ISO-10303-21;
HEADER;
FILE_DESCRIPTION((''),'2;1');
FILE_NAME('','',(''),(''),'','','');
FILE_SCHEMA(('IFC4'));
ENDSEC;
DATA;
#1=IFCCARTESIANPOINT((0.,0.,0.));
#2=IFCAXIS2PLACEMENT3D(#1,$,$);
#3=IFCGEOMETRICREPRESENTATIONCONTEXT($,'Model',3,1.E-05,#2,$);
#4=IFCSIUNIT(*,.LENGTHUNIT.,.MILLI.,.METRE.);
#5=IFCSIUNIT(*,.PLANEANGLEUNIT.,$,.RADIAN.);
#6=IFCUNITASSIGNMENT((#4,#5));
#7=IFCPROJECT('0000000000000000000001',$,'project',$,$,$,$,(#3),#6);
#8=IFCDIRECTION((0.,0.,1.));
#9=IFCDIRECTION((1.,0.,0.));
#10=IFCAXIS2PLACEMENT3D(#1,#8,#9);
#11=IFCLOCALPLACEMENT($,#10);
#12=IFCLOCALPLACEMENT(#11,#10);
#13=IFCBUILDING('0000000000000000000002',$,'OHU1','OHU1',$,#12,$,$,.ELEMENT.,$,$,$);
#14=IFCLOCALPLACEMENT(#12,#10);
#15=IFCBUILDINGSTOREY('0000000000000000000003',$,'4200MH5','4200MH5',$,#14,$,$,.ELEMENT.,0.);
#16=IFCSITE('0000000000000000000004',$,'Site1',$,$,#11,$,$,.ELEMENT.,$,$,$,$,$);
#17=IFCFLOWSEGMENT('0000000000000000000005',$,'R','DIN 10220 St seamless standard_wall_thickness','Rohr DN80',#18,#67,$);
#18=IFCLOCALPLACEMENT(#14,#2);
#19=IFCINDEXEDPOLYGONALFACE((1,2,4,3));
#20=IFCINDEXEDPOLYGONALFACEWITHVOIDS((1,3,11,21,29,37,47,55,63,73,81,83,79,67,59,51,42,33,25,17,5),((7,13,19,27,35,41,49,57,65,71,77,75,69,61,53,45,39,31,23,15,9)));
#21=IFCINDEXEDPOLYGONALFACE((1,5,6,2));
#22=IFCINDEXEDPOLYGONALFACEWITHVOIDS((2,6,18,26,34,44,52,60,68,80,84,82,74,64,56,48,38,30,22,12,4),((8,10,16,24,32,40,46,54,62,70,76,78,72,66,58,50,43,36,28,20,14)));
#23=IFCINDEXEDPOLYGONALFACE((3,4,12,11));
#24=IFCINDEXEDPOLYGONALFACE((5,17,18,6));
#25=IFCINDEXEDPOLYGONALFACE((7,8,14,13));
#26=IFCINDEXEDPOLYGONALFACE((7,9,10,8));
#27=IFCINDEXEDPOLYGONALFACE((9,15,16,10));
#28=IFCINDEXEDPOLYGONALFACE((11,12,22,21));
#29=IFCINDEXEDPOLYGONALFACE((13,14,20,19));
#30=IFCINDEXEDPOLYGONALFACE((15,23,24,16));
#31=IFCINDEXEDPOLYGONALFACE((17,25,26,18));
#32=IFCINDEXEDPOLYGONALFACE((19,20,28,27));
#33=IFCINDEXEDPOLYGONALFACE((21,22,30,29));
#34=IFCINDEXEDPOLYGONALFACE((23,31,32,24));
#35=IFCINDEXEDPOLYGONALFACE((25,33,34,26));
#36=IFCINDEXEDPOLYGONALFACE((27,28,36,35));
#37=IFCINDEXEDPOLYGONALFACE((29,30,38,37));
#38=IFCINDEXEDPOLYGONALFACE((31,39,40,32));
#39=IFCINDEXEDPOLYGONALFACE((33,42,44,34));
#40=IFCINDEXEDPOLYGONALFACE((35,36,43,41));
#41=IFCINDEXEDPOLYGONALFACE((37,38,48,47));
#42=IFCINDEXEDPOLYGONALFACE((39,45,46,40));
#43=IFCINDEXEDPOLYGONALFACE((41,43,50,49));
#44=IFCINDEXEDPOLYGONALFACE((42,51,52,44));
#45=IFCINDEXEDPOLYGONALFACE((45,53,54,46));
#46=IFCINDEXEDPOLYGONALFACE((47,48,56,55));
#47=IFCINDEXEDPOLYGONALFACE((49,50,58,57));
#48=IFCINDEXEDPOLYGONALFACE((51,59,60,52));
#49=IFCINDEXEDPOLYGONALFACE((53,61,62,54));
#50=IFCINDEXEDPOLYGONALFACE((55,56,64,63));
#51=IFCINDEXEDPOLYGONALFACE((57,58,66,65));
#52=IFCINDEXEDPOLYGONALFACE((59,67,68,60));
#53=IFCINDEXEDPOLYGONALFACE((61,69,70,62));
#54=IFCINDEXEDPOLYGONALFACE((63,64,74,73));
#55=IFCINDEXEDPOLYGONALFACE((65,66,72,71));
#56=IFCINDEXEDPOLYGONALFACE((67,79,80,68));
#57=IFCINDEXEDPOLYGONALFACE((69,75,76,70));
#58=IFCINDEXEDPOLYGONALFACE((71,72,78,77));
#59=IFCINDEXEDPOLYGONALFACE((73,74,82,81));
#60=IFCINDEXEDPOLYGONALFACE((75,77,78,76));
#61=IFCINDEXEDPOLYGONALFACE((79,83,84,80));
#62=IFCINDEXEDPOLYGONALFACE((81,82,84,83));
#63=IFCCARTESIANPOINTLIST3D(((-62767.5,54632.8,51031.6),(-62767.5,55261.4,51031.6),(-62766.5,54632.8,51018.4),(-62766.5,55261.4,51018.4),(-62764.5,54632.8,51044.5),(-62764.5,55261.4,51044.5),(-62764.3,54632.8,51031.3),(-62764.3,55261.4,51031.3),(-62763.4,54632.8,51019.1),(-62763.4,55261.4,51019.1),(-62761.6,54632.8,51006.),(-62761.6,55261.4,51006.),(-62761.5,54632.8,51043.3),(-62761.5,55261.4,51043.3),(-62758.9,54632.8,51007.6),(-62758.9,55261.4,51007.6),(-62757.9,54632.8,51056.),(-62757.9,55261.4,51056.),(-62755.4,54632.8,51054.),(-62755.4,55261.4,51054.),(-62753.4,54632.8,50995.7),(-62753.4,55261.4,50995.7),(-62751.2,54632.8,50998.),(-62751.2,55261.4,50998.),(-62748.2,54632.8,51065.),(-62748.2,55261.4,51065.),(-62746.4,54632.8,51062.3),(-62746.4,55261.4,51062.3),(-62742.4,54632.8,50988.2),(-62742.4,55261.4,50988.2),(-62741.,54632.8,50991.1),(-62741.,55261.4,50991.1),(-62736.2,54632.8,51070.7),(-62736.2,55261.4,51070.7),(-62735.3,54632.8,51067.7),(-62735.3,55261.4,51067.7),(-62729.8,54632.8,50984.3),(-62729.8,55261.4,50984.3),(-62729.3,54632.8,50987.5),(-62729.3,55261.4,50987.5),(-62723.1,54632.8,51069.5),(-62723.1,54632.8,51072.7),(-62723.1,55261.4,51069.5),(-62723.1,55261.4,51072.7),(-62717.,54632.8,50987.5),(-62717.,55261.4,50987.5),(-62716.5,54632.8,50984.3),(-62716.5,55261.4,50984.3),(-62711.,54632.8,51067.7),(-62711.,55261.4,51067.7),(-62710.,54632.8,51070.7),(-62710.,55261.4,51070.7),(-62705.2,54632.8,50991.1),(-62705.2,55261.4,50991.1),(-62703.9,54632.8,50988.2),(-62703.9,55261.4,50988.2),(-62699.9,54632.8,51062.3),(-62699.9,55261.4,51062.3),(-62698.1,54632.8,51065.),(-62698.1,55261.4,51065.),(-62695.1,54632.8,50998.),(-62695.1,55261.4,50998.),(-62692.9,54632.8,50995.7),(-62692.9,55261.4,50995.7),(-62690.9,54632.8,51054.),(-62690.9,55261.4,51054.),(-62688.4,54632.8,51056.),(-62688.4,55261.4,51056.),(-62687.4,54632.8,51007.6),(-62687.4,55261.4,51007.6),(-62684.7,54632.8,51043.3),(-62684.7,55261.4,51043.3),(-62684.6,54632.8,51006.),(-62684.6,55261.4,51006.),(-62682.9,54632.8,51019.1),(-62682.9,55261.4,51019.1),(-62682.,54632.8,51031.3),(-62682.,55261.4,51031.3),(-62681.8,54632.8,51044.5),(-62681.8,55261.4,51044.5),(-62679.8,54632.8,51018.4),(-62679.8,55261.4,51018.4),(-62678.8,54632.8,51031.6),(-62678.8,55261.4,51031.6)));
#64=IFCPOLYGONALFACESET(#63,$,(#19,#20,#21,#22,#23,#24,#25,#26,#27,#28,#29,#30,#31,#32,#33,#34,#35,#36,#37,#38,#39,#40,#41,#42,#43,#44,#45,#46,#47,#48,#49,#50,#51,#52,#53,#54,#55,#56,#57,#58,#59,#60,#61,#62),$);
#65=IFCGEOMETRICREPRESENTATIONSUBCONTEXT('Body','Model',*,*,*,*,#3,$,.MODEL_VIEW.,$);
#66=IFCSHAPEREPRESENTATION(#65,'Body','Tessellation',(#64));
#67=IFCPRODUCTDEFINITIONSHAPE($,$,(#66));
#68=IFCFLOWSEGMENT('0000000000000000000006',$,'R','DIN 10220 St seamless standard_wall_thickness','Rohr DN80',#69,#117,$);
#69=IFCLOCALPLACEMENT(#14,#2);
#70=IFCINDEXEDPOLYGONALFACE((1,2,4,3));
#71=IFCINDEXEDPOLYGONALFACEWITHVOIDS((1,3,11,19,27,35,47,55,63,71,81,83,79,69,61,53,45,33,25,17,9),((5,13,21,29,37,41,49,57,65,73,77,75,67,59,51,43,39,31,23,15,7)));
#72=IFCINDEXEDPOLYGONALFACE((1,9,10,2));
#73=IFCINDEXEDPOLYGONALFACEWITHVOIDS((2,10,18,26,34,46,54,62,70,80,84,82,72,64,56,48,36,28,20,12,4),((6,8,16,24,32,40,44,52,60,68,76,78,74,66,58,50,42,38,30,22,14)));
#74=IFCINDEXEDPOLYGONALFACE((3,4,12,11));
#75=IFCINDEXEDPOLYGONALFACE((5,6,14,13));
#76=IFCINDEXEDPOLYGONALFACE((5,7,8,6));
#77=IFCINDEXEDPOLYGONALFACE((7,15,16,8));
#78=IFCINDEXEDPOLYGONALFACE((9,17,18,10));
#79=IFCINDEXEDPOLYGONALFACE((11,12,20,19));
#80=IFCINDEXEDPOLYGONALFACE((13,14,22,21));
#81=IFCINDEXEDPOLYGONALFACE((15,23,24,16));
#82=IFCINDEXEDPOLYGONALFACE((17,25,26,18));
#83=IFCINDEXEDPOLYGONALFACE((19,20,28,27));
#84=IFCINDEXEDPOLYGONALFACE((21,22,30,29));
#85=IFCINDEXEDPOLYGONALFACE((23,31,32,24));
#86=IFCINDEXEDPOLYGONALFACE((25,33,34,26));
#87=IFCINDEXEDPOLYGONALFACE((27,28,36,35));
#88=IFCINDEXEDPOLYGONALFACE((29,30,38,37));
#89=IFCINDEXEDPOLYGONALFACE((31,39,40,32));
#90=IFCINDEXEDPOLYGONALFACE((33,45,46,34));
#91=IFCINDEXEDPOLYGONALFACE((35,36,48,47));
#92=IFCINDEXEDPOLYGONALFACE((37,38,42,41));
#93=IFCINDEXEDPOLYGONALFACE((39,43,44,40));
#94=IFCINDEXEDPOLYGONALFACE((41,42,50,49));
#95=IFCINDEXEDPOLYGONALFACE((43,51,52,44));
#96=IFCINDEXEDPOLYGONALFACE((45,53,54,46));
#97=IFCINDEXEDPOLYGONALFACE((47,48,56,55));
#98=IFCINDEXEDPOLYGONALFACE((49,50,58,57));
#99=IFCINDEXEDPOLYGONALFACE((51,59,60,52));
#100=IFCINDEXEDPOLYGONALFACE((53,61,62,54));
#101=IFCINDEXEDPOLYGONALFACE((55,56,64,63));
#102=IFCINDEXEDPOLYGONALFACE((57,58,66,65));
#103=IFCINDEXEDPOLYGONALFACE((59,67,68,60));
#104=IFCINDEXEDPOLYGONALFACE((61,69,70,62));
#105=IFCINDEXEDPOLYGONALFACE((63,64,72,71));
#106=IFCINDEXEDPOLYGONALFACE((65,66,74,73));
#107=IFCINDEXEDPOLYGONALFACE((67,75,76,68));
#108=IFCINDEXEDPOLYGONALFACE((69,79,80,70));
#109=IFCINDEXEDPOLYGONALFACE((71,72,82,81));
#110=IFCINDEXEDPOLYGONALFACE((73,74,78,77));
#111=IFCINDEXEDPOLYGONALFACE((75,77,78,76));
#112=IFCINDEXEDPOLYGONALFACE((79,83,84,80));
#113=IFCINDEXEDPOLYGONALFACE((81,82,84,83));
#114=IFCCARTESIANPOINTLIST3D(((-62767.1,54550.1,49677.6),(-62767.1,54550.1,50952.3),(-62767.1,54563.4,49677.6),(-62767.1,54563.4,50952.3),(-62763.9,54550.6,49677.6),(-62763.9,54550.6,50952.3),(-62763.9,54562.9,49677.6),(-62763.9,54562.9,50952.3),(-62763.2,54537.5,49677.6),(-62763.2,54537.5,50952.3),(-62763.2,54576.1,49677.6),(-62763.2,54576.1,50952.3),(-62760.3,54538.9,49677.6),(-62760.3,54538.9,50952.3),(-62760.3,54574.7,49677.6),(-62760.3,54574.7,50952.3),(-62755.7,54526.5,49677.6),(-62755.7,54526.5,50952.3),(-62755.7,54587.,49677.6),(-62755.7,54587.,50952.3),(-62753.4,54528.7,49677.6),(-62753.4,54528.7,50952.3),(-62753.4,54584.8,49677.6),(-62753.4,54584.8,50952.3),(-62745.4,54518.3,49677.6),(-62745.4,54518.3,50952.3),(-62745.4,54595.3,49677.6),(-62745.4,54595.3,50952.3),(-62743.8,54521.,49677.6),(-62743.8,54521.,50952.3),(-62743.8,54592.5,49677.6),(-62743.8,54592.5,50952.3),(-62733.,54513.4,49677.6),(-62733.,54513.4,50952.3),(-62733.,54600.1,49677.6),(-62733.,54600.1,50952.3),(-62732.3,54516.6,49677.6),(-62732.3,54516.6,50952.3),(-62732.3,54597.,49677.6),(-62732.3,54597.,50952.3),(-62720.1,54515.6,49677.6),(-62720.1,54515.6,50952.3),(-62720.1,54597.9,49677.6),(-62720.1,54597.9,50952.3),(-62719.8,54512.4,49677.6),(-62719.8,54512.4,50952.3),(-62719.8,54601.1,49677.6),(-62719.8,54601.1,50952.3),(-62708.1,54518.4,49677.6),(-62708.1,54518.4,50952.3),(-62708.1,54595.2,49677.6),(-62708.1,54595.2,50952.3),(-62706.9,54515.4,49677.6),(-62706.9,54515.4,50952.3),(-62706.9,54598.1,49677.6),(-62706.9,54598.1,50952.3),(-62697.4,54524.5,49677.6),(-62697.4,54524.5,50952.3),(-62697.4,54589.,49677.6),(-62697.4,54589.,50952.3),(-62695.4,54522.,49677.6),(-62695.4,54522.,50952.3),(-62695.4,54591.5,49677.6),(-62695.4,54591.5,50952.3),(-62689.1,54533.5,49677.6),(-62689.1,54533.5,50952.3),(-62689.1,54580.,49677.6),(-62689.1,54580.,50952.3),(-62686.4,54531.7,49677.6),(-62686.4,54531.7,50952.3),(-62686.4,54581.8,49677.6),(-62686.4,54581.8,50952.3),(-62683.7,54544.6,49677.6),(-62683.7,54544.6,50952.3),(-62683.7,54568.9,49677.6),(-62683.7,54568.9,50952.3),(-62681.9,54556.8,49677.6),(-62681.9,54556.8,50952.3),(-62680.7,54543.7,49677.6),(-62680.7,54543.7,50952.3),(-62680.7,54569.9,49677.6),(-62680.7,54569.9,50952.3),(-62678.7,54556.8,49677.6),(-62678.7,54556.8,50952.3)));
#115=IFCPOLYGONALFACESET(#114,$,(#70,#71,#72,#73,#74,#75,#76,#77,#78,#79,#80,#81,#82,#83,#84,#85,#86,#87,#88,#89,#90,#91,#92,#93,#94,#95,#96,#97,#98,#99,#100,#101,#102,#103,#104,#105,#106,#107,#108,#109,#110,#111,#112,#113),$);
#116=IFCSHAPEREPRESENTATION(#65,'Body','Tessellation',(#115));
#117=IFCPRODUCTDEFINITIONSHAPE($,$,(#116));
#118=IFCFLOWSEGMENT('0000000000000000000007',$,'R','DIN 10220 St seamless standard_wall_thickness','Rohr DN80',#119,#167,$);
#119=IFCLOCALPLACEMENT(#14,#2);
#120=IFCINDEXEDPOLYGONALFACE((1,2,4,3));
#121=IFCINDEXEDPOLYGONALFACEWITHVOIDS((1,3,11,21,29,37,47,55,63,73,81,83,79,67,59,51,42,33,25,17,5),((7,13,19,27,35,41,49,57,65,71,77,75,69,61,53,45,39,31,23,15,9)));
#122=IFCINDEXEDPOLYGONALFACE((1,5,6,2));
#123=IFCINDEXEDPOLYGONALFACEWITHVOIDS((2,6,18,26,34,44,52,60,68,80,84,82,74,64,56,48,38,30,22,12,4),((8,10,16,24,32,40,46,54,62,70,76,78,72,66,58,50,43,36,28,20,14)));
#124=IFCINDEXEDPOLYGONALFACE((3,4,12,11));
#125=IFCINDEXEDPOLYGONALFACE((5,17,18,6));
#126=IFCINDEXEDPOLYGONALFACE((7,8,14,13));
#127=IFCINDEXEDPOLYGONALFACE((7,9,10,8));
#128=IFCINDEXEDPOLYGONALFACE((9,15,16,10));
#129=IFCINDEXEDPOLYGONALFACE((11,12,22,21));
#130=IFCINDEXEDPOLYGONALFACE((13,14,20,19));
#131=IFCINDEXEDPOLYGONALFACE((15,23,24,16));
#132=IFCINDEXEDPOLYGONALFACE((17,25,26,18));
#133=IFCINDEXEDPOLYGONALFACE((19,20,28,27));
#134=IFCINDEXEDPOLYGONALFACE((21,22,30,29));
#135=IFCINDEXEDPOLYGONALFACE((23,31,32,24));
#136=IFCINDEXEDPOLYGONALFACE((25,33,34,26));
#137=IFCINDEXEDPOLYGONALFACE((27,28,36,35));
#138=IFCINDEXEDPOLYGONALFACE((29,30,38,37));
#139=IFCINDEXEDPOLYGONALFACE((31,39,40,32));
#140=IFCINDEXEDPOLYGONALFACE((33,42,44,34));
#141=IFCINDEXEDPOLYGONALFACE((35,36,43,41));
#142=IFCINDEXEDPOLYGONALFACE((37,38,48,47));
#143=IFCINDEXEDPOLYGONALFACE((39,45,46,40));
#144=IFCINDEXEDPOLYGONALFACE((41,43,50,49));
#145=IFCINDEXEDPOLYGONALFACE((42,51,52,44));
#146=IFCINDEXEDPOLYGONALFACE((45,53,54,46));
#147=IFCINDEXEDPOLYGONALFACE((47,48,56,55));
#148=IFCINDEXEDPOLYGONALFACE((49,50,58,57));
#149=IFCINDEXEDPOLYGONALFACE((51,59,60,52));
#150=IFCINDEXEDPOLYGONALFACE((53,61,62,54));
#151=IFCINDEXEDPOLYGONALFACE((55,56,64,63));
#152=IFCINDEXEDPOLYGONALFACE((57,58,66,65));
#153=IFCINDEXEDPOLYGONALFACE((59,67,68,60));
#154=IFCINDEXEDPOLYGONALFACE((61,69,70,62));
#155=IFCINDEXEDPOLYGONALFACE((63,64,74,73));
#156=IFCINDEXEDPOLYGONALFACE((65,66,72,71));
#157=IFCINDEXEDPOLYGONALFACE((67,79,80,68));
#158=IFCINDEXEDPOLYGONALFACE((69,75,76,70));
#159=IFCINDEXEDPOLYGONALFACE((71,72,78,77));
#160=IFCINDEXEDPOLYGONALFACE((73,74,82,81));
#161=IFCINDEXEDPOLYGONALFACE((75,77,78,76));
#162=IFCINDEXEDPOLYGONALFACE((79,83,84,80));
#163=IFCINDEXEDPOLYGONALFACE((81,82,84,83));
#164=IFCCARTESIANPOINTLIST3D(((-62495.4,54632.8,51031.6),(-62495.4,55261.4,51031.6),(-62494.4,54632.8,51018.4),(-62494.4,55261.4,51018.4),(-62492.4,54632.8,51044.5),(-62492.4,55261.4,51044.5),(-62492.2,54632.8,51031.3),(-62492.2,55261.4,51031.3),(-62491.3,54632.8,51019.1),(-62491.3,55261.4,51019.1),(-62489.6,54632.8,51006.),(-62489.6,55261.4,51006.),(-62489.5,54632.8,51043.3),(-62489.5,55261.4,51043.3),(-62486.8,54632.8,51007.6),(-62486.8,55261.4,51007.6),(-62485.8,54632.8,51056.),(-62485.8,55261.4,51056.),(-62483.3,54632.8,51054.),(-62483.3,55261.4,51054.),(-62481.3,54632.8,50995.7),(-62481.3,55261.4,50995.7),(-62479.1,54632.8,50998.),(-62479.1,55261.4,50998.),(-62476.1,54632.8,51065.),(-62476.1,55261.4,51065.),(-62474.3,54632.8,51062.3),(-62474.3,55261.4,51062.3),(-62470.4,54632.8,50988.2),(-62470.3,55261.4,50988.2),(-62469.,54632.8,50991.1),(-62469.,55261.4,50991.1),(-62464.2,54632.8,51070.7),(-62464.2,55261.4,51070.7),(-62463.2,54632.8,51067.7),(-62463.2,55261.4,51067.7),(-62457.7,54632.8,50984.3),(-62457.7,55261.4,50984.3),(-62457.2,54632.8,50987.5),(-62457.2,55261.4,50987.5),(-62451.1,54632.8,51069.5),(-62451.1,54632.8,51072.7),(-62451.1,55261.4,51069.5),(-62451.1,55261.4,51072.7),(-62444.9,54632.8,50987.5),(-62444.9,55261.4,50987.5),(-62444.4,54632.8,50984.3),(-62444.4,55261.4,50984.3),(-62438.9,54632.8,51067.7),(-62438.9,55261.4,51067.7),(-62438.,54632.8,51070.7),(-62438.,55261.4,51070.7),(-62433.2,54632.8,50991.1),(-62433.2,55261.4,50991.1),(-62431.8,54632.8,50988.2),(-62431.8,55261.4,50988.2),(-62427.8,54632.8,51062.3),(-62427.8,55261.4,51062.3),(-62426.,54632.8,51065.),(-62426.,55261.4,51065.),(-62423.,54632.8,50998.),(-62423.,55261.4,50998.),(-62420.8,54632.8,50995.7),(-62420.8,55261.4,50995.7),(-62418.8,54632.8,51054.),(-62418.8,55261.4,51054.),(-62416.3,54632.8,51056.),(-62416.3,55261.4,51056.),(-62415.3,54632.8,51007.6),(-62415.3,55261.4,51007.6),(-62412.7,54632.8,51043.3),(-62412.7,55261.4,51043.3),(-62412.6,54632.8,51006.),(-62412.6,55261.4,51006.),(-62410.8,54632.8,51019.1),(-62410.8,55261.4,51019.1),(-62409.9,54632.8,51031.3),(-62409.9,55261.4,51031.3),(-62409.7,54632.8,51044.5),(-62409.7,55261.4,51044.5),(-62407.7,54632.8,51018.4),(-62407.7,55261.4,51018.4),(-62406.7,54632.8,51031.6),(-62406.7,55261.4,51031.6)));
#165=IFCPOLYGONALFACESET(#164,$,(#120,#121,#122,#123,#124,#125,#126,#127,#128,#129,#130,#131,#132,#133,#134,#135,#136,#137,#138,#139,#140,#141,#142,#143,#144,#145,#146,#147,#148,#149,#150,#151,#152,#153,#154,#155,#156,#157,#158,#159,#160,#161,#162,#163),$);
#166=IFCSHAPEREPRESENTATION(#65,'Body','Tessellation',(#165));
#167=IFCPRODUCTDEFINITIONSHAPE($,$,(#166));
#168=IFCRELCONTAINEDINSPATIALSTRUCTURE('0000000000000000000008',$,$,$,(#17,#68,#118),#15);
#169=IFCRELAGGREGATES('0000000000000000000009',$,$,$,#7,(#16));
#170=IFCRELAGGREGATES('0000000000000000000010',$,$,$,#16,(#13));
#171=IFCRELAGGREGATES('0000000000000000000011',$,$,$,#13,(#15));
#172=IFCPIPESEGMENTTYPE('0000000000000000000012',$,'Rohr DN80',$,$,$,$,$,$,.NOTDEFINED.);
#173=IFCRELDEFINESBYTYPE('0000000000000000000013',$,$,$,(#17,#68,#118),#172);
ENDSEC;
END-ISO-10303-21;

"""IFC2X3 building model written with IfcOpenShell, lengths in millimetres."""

from ifc_helpers import new_model, si_unit, frame, origin, origin_with_axes, origin_2d_with_axis, place, context, subcontext, project, spatial, hollow_circle, extrude, type_object, element, save


model = new_model("IFC2X3")

# Units and contexts
model_context = context("Model", 3, precision=1e-05, world=origin())
body_context = subcontext(model_context, "Body", "Model", "MODEL_VIEW")
ifc_project = project(units=[si_unit("LENGTHUNIT", "METRE", prefix="MILLI"), si_unit("PLANEANGLEUNIT", "RADIAN")], contexts=[model_context])

# Site, building, storey
site_placement = place(None, origin_with_axes())
site = spatial("IfcSite", under=ifc_project, at=site_placement, Name="Site1", CompositionType="ELEMENT")
building_placement = place(site_placement, origin_with_axes())
building = spatial("IfcBuilding", under=site, at=building_placement, Name="OHU1", Description="OHU1", CompositionType="ELEMENT")
storey_placement = place(building_placement, origin_with_axes())
storey = spatial("IfcBuildingStorey", under=building, at=storey_placement, Name="4200MH5", Description="4200MH5", CompositionType="ELEMENT", Elevation=0.0)

# Flow segments
pipe_segment_type_1 = type_object("IfcPipeSegmentType", Name="Rohr DN80", PredefinedType="NOTDEFINED")
flow_segment_1_placement = place(storey_placement, frame((-62723.1, 54947.1, 51028.3), z_axis=(0.0, 0.0, 1.0), x_axis=(1.0, 0.0, 0.0)))
element("IfcFlowSegment", 1, at=flow_segment_1_placement, inside=storey, type_object=pipe_segment_type_1, Name="R", Description="DIN 10220 St seamless standard_wall_thickness", ObjectType="Rohr DN80", context=body_context, shape_type="SweptSolid", body=[
    extrude(hollow_circle(Radius=44.5, WallThickness=3.2, at=origin_2d_with_axis()), frame((0.0, -314.3, 0.0), z_axis=(0.000003, 1.0, 0.0), x_axis=(0.0, 0.0, 1.0)), (0.0, 0.0, 1.0), 628.7),
])
flow_segment_2_placement = place(storey_placement, frame((-62723.1, 54556.8, 50314.9), z_axis=(0.0, 0.0, 1.0), x_axis=(1.0, 0.0, 0.0)))
element("IfcFlowSegment", 2, at=flow_segment_2_placement, inside=storey, type_object=pipe_segment_type_1, Name="R", Description="DIN 10220 St seamless standard_wall_thickness", ObjectType="Rohr DN80", context=body_context, shape_type="SweptSolid", body=[
    extrude(hollow_circle(Radius=44.5, WallThickness=3.2, at=origin_2d_with_axis()), frame((0.0, 0.0, 637.3), z_axis=(0.0, 0.0, -1.0), x_axis=(1.0, 0.0, 0.0)), (0.0, 0.0, 1.0), 1274.7),
])
flow_segment_3_placement = place(storey_placement, frame((-62451.1, 54947.1, 51028.3), z_axis=(0.0, 0.0, 1.0), x_axis=(1.0, 0.0, 0.0)))
element("IfcFlowSegment", 3, at=flow_segment_3_placement, inside=storey, type_object=pipe_segment_type_1, Name="R", Description="DIN 10220 St seamless standard_wall_thickness", ObjectType="Rohr DN80", context=body_context, shape_type="SweptSolid", body=[
    extrude(hollow_circle(Radius=44.5, WallThickness=3.2, at=origin_2d_with_axis()), frame((0.0, -314.3, 0.0), z_axis=(0.000003, 1.0, 0.0), x_axis=(0.0, 0.0, 1.0)), (0.0, 0.0, 1.0), 628.7),
])

save(model, "model.ifc")
